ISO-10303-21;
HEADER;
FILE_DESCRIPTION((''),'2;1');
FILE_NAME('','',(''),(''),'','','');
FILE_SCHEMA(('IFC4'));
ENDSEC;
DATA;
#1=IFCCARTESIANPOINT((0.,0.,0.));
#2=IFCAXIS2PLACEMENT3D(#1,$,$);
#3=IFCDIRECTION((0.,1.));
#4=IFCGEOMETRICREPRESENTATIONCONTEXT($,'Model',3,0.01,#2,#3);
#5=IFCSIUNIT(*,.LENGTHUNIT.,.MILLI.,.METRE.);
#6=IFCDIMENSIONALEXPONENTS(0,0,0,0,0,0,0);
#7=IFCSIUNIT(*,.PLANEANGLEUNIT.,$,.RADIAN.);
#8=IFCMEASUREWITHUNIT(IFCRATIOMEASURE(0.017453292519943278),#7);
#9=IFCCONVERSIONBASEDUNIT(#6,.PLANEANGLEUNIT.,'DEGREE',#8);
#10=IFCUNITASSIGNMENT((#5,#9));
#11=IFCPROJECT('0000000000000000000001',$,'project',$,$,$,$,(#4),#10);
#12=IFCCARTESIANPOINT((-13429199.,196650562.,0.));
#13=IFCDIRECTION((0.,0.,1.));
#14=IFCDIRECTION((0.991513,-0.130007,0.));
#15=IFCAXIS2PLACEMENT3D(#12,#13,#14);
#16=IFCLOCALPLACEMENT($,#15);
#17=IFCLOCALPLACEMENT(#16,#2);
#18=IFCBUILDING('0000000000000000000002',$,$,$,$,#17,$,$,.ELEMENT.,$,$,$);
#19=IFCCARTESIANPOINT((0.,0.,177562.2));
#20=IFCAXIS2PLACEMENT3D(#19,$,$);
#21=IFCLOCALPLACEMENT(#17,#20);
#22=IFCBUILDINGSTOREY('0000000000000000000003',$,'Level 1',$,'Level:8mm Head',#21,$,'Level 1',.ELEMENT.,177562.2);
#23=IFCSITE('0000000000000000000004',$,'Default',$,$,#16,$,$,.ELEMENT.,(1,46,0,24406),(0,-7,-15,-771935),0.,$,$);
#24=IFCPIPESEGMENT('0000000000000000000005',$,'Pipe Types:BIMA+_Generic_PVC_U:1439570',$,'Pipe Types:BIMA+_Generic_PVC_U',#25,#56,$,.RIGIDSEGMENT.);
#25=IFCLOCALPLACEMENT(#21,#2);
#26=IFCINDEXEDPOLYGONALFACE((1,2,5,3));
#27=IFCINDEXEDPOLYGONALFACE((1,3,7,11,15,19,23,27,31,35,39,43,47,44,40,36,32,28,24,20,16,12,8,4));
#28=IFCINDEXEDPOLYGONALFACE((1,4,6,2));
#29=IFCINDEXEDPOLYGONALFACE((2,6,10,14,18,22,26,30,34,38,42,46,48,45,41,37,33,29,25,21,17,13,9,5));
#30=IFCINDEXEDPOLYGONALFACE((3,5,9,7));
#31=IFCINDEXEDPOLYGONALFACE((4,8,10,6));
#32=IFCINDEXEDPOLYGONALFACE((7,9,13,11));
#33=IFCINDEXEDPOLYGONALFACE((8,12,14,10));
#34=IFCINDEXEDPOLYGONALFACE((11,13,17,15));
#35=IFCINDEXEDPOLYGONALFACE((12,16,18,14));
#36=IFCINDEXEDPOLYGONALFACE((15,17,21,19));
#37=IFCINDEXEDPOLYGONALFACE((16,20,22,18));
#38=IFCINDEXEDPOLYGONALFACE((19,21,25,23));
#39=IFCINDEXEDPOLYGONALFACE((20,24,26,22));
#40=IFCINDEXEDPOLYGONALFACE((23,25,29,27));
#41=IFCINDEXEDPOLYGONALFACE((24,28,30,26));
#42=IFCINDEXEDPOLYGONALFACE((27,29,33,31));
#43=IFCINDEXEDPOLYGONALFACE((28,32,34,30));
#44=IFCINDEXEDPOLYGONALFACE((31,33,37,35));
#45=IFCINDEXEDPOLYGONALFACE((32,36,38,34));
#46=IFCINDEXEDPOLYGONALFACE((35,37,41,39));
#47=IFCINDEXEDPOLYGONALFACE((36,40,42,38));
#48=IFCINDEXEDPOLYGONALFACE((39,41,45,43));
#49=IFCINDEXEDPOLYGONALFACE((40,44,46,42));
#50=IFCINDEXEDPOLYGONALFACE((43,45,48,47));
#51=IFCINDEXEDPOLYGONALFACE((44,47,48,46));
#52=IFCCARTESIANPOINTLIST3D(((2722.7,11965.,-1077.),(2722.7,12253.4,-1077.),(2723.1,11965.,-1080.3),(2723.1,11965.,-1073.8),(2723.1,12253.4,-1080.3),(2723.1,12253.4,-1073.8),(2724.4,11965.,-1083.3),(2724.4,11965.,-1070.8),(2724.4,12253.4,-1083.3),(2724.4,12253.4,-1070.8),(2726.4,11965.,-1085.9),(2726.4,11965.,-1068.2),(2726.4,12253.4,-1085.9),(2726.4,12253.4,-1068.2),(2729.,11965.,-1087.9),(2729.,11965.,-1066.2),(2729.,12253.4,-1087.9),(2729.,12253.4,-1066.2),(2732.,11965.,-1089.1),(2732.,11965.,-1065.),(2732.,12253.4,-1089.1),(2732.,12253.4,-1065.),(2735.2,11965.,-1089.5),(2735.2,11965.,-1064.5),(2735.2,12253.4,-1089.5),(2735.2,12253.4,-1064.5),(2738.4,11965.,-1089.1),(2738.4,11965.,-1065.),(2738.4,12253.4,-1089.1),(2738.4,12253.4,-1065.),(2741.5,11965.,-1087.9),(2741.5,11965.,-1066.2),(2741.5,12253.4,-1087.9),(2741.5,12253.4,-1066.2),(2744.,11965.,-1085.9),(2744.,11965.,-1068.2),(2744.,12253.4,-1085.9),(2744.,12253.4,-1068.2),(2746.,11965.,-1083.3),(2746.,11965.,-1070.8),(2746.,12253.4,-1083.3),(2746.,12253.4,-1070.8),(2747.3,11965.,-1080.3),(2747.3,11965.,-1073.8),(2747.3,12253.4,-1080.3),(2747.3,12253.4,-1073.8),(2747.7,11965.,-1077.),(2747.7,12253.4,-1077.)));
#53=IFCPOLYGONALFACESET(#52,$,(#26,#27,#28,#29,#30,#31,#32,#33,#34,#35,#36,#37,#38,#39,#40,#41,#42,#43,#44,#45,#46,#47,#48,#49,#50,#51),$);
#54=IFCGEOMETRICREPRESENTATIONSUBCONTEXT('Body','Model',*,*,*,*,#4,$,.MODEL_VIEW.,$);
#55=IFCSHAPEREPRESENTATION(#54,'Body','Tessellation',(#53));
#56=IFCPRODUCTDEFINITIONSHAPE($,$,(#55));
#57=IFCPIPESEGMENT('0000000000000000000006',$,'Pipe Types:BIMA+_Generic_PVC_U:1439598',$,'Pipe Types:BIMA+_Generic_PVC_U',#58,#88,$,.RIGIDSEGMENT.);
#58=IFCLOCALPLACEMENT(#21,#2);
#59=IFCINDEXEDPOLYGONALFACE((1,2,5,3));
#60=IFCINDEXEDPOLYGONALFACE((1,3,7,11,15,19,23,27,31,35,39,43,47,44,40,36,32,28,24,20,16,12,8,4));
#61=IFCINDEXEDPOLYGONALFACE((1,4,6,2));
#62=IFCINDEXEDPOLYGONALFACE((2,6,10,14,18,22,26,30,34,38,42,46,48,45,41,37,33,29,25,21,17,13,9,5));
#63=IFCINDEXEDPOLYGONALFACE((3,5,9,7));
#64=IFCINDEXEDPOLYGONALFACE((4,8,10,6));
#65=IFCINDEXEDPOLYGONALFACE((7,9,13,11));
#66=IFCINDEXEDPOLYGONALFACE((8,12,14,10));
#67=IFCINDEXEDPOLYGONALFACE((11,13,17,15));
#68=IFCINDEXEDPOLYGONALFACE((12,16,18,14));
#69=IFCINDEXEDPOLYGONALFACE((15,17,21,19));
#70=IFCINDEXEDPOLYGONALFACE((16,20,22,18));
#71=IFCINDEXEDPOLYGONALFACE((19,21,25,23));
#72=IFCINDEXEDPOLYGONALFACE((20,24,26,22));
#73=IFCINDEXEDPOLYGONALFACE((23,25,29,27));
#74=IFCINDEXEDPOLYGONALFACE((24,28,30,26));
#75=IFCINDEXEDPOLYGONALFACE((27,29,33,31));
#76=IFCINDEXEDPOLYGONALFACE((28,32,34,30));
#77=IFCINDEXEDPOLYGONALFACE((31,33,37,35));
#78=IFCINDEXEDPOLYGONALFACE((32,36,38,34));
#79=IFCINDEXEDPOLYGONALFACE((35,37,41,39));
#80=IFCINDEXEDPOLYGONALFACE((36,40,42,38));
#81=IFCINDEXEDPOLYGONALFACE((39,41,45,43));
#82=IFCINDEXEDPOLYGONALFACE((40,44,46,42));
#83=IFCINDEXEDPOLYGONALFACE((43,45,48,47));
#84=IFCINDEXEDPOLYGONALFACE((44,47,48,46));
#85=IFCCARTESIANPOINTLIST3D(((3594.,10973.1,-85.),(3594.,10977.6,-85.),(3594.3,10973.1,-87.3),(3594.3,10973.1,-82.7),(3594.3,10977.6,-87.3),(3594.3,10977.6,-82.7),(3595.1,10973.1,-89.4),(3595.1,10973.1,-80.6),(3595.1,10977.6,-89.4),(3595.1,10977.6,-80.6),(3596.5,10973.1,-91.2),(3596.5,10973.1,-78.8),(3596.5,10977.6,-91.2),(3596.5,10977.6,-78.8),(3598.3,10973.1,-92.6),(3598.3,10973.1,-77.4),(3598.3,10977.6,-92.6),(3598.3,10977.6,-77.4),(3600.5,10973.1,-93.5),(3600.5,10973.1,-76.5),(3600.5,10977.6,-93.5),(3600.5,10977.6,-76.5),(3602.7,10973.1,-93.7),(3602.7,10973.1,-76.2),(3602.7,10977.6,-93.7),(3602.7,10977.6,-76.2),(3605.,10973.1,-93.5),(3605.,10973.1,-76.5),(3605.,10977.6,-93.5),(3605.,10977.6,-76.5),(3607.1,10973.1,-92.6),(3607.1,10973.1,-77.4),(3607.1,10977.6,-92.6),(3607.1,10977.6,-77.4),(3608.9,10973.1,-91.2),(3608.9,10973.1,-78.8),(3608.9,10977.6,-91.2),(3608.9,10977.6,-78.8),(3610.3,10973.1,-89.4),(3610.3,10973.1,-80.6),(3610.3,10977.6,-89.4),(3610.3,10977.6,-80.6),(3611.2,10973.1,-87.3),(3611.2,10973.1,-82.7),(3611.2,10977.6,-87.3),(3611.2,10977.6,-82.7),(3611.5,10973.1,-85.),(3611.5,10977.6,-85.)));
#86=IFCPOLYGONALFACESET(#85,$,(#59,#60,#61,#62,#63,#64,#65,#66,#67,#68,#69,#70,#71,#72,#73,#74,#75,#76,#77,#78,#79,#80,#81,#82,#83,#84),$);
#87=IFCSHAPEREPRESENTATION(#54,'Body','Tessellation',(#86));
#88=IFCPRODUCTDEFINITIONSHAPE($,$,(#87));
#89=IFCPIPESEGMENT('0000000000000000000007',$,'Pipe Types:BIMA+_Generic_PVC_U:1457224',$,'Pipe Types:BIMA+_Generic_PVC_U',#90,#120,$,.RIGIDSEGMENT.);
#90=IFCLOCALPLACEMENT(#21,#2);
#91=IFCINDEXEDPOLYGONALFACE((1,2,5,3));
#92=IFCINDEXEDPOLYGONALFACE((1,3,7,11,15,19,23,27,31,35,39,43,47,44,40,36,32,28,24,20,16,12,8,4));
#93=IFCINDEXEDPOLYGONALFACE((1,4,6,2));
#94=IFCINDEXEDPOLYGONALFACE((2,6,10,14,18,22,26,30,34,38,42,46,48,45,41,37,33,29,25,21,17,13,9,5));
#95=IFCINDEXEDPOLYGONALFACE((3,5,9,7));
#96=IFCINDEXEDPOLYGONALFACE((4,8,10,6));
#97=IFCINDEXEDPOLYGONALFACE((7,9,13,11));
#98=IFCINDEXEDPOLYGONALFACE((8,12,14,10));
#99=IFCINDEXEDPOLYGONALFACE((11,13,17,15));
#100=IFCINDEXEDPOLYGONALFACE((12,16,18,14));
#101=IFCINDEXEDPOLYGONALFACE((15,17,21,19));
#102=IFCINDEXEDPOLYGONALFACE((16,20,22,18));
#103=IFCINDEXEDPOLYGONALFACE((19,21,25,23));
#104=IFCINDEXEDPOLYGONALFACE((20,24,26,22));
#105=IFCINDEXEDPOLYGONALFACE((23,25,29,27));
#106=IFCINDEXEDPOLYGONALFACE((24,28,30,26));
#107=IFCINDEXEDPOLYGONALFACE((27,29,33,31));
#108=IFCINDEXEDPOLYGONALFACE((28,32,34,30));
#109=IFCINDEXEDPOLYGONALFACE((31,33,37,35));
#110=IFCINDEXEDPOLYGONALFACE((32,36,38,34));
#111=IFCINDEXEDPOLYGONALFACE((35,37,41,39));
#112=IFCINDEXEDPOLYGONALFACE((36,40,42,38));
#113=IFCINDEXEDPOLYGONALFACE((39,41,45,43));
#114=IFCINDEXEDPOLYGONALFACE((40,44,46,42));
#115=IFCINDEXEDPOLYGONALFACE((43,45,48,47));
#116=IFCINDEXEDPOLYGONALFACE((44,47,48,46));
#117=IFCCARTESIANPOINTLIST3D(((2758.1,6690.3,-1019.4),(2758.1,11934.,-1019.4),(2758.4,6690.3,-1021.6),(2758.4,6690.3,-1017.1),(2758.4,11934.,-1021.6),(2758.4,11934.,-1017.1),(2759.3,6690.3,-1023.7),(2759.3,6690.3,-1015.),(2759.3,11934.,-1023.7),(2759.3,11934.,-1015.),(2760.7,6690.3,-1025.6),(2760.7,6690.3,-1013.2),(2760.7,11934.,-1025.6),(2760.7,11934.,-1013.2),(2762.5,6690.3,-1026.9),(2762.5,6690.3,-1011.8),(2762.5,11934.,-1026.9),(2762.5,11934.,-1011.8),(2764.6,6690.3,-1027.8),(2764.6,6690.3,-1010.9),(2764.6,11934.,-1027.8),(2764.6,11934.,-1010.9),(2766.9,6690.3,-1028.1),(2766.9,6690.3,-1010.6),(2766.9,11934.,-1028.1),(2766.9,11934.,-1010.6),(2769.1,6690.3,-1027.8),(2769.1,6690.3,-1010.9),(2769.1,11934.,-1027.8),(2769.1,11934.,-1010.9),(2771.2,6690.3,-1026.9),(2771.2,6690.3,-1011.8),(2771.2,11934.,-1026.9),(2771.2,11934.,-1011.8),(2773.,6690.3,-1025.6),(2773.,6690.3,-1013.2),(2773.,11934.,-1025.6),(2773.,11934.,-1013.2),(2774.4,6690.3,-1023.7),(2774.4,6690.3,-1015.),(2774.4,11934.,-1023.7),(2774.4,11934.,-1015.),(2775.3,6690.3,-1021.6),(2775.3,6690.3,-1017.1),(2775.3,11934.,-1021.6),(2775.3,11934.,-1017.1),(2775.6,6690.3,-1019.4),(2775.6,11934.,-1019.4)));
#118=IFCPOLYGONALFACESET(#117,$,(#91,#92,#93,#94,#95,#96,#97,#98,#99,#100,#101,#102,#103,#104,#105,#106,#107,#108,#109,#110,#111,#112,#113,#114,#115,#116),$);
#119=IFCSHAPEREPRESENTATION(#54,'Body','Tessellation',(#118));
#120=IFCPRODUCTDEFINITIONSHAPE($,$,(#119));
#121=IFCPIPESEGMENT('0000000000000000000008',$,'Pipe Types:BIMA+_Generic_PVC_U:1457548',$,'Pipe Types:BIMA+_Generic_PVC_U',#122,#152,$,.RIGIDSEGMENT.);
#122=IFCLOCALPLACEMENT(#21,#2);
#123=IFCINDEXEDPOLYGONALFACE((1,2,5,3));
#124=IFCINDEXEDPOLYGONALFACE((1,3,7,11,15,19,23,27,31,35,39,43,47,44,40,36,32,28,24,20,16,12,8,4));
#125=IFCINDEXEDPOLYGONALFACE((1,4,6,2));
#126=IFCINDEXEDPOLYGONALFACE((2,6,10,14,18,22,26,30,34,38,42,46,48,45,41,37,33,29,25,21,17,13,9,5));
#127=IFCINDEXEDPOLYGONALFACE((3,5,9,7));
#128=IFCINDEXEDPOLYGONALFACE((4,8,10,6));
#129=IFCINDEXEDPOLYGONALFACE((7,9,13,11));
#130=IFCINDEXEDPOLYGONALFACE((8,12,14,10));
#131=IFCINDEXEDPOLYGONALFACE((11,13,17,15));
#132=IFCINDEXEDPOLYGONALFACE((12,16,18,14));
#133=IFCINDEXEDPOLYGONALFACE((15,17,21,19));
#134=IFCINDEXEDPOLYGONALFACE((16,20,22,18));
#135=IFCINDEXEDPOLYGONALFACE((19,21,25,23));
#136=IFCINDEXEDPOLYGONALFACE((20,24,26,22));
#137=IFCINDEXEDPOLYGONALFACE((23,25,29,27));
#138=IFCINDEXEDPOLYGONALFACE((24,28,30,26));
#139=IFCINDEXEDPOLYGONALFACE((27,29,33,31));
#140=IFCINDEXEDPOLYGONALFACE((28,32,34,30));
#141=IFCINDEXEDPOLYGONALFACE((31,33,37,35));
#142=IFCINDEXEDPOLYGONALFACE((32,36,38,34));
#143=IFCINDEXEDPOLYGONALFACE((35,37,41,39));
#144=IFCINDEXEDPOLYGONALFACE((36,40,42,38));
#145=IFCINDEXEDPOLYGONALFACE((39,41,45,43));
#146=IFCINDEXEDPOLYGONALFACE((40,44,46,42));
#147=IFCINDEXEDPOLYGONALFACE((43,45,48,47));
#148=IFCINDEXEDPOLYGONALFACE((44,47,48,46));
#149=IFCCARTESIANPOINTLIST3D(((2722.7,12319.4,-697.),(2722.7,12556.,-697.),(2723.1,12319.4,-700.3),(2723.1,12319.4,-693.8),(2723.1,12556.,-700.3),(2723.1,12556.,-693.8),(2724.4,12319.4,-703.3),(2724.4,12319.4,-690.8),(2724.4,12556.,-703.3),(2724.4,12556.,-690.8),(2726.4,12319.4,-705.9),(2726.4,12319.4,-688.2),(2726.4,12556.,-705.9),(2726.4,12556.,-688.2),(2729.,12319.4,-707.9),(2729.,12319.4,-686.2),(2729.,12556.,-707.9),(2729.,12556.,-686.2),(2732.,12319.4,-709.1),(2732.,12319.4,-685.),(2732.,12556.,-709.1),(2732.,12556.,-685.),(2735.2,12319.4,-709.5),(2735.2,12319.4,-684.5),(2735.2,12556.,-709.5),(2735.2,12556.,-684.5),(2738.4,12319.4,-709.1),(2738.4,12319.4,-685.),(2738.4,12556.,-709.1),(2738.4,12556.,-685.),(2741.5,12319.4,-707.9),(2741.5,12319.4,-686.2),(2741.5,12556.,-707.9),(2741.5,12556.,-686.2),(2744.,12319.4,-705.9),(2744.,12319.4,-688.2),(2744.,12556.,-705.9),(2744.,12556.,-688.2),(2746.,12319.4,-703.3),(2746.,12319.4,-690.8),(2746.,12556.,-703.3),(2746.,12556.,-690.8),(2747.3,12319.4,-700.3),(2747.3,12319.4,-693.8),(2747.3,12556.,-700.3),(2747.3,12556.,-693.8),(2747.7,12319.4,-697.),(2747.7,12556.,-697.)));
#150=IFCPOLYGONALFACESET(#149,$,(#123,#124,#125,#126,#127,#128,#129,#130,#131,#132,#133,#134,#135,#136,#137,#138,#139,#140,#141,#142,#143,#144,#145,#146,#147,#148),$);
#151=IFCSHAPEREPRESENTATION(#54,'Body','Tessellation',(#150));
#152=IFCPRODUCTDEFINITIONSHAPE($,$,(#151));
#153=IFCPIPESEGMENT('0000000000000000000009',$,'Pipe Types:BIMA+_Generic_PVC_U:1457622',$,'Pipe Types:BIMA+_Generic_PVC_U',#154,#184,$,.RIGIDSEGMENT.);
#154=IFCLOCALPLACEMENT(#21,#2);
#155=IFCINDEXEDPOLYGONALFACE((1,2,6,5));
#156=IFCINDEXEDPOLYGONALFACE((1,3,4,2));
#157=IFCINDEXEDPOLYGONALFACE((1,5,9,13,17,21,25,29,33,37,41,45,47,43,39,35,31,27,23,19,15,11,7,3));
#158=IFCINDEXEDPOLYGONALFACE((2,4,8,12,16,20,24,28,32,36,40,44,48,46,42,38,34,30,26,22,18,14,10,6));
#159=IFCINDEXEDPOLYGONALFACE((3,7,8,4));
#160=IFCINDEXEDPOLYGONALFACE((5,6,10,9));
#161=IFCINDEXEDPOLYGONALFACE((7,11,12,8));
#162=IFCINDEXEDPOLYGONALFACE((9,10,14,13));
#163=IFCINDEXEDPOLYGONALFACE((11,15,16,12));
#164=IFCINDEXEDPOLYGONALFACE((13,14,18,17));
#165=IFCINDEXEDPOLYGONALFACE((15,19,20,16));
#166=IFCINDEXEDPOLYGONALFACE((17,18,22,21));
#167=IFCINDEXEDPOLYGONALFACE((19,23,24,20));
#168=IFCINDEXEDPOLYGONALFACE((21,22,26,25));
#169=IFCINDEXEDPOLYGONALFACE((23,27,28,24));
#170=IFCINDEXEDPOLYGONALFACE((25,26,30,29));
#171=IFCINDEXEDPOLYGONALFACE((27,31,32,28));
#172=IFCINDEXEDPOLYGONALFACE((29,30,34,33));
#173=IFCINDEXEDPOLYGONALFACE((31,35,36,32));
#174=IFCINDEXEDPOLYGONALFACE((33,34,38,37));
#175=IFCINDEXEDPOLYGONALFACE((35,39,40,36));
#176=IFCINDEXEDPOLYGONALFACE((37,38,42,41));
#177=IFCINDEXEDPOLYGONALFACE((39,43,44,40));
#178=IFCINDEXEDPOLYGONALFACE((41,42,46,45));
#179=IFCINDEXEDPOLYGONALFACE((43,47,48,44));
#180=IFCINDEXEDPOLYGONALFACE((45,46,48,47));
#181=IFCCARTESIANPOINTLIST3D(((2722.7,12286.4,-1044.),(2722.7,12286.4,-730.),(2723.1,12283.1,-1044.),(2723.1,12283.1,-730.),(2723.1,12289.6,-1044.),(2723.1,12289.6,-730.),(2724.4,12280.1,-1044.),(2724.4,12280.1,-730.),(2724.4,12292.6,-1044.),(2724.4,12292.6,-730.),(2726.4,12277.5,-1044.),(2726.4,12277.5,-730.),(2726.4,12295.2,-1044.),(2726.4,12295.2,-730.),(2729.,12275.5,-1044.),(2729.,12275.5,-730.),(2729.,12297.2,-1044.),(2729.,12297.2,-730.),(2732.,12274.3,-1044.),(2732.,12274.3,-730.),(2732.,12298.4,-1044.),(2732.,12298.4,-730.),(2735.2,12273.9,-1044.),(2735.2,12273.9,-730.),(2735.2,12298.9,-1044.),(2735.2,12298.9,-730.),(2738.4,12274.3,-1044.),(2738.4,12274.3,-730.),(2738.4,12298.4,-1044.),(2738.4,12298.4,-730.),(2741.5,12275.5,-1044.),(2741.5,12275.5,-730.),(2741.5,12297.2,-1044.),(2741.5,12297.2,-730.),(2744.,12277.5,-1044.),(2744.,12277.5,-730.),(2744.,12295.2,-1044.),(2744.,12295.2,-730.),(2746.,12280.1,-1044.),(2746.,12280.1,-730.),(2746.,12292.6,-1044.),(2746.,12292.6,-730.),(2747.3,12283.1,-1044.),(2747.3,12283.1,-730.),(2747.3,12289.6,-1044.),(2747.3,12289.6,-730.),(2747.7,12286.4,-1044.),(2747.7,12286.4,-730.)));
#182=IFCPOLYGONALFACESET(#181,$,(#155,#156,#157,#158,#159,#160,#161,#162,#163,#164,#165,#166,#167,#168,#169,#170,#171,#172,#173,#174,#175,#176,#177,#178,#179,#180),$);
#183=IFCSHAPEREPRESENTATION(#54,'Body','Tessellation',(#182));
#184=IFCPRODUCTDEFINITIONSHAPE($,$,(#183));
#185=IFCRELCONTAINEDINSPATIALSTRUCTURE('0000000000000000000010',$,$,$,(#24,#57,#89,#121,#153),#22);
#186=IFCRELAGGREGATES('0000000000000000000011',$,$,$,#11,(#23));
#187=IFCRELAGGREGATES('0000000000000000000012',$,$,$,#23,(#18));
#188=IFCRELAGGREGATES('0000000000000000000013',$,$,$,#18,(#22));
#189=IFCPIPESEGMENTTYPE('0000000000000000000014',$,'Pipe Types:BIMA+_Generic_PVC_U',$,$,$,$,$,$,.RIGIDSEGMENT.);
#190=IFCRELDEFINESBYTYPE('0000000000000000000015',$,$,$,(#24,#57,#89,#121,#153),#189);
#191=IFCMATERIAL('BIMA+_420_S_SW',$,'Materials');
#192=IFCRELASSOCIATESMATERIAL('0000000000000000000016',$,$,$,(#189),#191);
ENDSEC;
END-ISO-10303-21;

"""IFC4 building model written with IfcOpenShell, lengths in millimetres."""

from ifc_helpers import new_model, entity, si_unit, converted_unit, direction, frame, origin, place, context, subcontext, project, spatial, arc, indexed_curve, outline, extrude, material, type_object, element, save


model = new_model("IFC4")

# Units and contexts
model_context = context("Model", 3, precision=0.01, world=origin(), true_north=direction((0.0, 1.0)))
body_context = subcontext(model_context, "Body", "Model", "MODEL_VIEW")
ifc_project = project(units=[si_unit("LENGTHUNIT", "METRE", prefix="MILLI"), converted_unit("PLANEANGLEUNIT", "DEGREE", entity("IfcRatioMeasure", 0.017453292519943278), si_unit("PLANEANGLEUNIT", "RADIAN"), dimensions=[0, 0, 0, 0, 0, 0, 0])], contexts=[model_context])

# Site, building, storey
site_placement = place(None, frame((-13429199.0, 196650562.0, 0.0), z_axis=(0.0, 0.0, 1.0), x_axis=(0.991513, -0.130007, 0.0)))
site = spatial("IfcSite", under=ifc_project, at=site_placement, Name="Default", CompositionType="ELEMENT", RefLatitude=(1, 46, 0, 24406), RefLongitude=(0, -7, -15, -771935), RefElevation=0.0)
building_placement = place(site_placement, origin())
building = spatial("IfcBuilding", under=site, at=building_placement, CompositionType="ELEMENT")
storey_placement = place(building_placement, frame((0.0, 0.0, 177562.2)))
storey = spatial("IfcBuildingStorey", under=building, at=storey_placement, Name="Level 1", ObjectType="Level:8mm Head", LongName="Level 1", CompositionType="ELEMENT", Elevation=177562.2)

# Pipe segments
ifc_material_1 = material(Name="BIMA+_420_S_SW", Category="Materials")
pipe_segment_type_1 = type_object("IfcPipeSegmentType", Name="Pipe Types:BIMA+_Generic_PVC_U", PredefinedType="RIGIDSEGMENT", material=ifc_material_1)
pipe_segment_1_placement = place(storey_placement, frame((2721.1, 11965.0, -1062.9)))
element("IfcPipeSegment", 1, at=pipe_segment_1_placement, inside=storey, type_object=pipe_segment_type_1, Name="Pipe Types:BIMA+_Generic_PVC_U:1439570", ObjectType="Pipe Types:BIMA+_Generic_PVC_U", PredefinedType="RIGIDSEGMENT", context=body_context, shape_type="SweptSolid", body=[
    extrude(outline(indexed_curve([(12.5, 0.0), (8.8, 8.8), (0.0, 12.5), (-8.8, 8.8), (-12.5, 0.0), (-8.8, -8.8), (0.0, -12.5), (8.8, -8.8)], segments=[arc(1, 2, 3), arc(3, 4, 5), arc(5, 6, 7), arc(7, 8, 1)], self_intersect=False)), frame((14.1, 0.0, -14.1), z_axis=(0.0, 1.0, 0.0), x_axis=(-1.0, 0.0, 0.0)), (0.0, 0.0, 1.0), 288.3),
])
pipe_segment_2_placement = place(storey_placement, frame((3592.4, 10973.1, -95.3)))
element("IfcPipeSegment", 2, at=pipe_segment_2_placement, inside=storey, type_object=pipe_segment_type_1, Name="Pipe Types:BIMA+_Generic_PVC_U:1439598", ObjectType="Pipe Types:BIMA+_Generic_PVC_U", PredefinedType="RIGIDSEGMENT", context=body_context, shape_type="SweptSolid", body=[
    extrude(outline(indexed_curve([(8.8, 0.0), (6.2, 6.2), (0.0, 8.8), (-6.2, 6.2), (-8.8, 0.0), (-6.2, -6.2), (0.0, -8.8), (6.2, -6.2)], segments=[arc(1, 2, 3), arc(3, 4, 5), arc(5, 6, 7), arc(7, 8, 1)], self_intersect=False)), frame((10.3, 0.0, 10.3), z_axis=(0.0, 1.0, 0.0), x_axis=(1.0, 0.0, 0.0)), (0.0, 0.0, 1.0), 4.5),
])
pipe_segment_3_placement = place(storey_placement, frame((2756.5, 6690.3, -1029.7)))
element("IfcPipeSegment", 3, at=pipe_segment_3_placement, inside=storey, type_object=pipe_segment_type_1, Name="Pipe Types:BIMA+_Generic_PVC_U:1457224", ObjectType="Pipe Types:BIMA+_Generic_PVC_U", PredefinedType="RIGIDSEGMENT", context=body_context, shape_type="SweptSolid", body=[
    extrude(outline(indexed_curve([(8.8, 0.0), (6.2, 6.2), (0.0, 8.8), (-6.2, 6.2), (-8.8, 0.0), (-6.2, -6.2), (0.0, -8.8), (6.2, -6.2)], segments=[arc(1, 2, 3), arc(3, 4, 5), arc(5, 6, 7), arc(7, 8, 1)], self_intersect=False)), frame((10.3, 0.0, 10.3), z_axis=(0.0, 1.0, 0.0), x_axis=(1.0, 0.0, 0.0)), (0.0, 0.0, 1.0), 5243.8),
])
pipe_segment_4_placement = place(storey_placement, frame((2721.1, 12319.4, -711.1)))
element("IfcPipeSegment", 4, at=pipe_segment_4_placement, inside=storey, type_object=pipe_segment_type_1, Name="Pipe Types:BIMA+_Generic_PVC_U:1457548", ObjectType="Pipe Types:BIMA+_Generic_PVC_U", PredefinedType="RIGIDSEGMENT", context=body_context, shape_type="SweptSolid", body=[
    extrude(outline(indexed_curve([(12.5, 0.0), (8.8, 8.8), (0.0, 12.5), (-8.8, 8.8), (-12.5, 0.0), (-8.8, -8.8), (0.0, -12.5), (8.8, -8.8)], segments=[arc(1, 2, 3), arc(3, 4, 5), arc(5, 6, 7), arc(7, 8, 1)], self_intersect=False)), frame((14.1, 0.0, 14.1), z_axis=(0.0, 1.0, 0.0), x_axis=(-1.0, 0.0, 0.0)), (0.0, 0.0, 1.0), 236.7),
])
pipe_segment_5_placement = place(storey_placement, frame((2721.1, 12272.3, -730.0)))
element("IfcPipeSegment", 5, at=pipe_segment_5_placement, inside=storey, type_object=pipe_segment_type_1, Name="Pipe Types:BIMA+_Generic_PVC_U:1457622", ObjectType="Pipe Types:BIMA+_Generic_PVC_U", PredefinedType="RIGIDSEGMENT", context=body_context, shape_type="SweptSolid", body=[
    extrude(outline(indexed_curve([(12.5, 0.0), (8.8, 8.8), (0.0, 12.5), (-8.8, 8.8), (-12.5, 0.0), (-8.8, -8.8), (0.0, -12.5), (8.8, -8.8)], segments=[arc(1, 2, 3), arc(3, 4, 5), arc(5, 6, 7), arc(7, 8, 1)], self_intersect=False)), frame((14.1, 14.1, -314.0), z_axis=(0.0, 0.0, 1.0), x_axis=(-1.0, 0.0, 0.0)), (0.0, 0.0, 1.0), 314.0),
])

save(model, "model.ifc")
